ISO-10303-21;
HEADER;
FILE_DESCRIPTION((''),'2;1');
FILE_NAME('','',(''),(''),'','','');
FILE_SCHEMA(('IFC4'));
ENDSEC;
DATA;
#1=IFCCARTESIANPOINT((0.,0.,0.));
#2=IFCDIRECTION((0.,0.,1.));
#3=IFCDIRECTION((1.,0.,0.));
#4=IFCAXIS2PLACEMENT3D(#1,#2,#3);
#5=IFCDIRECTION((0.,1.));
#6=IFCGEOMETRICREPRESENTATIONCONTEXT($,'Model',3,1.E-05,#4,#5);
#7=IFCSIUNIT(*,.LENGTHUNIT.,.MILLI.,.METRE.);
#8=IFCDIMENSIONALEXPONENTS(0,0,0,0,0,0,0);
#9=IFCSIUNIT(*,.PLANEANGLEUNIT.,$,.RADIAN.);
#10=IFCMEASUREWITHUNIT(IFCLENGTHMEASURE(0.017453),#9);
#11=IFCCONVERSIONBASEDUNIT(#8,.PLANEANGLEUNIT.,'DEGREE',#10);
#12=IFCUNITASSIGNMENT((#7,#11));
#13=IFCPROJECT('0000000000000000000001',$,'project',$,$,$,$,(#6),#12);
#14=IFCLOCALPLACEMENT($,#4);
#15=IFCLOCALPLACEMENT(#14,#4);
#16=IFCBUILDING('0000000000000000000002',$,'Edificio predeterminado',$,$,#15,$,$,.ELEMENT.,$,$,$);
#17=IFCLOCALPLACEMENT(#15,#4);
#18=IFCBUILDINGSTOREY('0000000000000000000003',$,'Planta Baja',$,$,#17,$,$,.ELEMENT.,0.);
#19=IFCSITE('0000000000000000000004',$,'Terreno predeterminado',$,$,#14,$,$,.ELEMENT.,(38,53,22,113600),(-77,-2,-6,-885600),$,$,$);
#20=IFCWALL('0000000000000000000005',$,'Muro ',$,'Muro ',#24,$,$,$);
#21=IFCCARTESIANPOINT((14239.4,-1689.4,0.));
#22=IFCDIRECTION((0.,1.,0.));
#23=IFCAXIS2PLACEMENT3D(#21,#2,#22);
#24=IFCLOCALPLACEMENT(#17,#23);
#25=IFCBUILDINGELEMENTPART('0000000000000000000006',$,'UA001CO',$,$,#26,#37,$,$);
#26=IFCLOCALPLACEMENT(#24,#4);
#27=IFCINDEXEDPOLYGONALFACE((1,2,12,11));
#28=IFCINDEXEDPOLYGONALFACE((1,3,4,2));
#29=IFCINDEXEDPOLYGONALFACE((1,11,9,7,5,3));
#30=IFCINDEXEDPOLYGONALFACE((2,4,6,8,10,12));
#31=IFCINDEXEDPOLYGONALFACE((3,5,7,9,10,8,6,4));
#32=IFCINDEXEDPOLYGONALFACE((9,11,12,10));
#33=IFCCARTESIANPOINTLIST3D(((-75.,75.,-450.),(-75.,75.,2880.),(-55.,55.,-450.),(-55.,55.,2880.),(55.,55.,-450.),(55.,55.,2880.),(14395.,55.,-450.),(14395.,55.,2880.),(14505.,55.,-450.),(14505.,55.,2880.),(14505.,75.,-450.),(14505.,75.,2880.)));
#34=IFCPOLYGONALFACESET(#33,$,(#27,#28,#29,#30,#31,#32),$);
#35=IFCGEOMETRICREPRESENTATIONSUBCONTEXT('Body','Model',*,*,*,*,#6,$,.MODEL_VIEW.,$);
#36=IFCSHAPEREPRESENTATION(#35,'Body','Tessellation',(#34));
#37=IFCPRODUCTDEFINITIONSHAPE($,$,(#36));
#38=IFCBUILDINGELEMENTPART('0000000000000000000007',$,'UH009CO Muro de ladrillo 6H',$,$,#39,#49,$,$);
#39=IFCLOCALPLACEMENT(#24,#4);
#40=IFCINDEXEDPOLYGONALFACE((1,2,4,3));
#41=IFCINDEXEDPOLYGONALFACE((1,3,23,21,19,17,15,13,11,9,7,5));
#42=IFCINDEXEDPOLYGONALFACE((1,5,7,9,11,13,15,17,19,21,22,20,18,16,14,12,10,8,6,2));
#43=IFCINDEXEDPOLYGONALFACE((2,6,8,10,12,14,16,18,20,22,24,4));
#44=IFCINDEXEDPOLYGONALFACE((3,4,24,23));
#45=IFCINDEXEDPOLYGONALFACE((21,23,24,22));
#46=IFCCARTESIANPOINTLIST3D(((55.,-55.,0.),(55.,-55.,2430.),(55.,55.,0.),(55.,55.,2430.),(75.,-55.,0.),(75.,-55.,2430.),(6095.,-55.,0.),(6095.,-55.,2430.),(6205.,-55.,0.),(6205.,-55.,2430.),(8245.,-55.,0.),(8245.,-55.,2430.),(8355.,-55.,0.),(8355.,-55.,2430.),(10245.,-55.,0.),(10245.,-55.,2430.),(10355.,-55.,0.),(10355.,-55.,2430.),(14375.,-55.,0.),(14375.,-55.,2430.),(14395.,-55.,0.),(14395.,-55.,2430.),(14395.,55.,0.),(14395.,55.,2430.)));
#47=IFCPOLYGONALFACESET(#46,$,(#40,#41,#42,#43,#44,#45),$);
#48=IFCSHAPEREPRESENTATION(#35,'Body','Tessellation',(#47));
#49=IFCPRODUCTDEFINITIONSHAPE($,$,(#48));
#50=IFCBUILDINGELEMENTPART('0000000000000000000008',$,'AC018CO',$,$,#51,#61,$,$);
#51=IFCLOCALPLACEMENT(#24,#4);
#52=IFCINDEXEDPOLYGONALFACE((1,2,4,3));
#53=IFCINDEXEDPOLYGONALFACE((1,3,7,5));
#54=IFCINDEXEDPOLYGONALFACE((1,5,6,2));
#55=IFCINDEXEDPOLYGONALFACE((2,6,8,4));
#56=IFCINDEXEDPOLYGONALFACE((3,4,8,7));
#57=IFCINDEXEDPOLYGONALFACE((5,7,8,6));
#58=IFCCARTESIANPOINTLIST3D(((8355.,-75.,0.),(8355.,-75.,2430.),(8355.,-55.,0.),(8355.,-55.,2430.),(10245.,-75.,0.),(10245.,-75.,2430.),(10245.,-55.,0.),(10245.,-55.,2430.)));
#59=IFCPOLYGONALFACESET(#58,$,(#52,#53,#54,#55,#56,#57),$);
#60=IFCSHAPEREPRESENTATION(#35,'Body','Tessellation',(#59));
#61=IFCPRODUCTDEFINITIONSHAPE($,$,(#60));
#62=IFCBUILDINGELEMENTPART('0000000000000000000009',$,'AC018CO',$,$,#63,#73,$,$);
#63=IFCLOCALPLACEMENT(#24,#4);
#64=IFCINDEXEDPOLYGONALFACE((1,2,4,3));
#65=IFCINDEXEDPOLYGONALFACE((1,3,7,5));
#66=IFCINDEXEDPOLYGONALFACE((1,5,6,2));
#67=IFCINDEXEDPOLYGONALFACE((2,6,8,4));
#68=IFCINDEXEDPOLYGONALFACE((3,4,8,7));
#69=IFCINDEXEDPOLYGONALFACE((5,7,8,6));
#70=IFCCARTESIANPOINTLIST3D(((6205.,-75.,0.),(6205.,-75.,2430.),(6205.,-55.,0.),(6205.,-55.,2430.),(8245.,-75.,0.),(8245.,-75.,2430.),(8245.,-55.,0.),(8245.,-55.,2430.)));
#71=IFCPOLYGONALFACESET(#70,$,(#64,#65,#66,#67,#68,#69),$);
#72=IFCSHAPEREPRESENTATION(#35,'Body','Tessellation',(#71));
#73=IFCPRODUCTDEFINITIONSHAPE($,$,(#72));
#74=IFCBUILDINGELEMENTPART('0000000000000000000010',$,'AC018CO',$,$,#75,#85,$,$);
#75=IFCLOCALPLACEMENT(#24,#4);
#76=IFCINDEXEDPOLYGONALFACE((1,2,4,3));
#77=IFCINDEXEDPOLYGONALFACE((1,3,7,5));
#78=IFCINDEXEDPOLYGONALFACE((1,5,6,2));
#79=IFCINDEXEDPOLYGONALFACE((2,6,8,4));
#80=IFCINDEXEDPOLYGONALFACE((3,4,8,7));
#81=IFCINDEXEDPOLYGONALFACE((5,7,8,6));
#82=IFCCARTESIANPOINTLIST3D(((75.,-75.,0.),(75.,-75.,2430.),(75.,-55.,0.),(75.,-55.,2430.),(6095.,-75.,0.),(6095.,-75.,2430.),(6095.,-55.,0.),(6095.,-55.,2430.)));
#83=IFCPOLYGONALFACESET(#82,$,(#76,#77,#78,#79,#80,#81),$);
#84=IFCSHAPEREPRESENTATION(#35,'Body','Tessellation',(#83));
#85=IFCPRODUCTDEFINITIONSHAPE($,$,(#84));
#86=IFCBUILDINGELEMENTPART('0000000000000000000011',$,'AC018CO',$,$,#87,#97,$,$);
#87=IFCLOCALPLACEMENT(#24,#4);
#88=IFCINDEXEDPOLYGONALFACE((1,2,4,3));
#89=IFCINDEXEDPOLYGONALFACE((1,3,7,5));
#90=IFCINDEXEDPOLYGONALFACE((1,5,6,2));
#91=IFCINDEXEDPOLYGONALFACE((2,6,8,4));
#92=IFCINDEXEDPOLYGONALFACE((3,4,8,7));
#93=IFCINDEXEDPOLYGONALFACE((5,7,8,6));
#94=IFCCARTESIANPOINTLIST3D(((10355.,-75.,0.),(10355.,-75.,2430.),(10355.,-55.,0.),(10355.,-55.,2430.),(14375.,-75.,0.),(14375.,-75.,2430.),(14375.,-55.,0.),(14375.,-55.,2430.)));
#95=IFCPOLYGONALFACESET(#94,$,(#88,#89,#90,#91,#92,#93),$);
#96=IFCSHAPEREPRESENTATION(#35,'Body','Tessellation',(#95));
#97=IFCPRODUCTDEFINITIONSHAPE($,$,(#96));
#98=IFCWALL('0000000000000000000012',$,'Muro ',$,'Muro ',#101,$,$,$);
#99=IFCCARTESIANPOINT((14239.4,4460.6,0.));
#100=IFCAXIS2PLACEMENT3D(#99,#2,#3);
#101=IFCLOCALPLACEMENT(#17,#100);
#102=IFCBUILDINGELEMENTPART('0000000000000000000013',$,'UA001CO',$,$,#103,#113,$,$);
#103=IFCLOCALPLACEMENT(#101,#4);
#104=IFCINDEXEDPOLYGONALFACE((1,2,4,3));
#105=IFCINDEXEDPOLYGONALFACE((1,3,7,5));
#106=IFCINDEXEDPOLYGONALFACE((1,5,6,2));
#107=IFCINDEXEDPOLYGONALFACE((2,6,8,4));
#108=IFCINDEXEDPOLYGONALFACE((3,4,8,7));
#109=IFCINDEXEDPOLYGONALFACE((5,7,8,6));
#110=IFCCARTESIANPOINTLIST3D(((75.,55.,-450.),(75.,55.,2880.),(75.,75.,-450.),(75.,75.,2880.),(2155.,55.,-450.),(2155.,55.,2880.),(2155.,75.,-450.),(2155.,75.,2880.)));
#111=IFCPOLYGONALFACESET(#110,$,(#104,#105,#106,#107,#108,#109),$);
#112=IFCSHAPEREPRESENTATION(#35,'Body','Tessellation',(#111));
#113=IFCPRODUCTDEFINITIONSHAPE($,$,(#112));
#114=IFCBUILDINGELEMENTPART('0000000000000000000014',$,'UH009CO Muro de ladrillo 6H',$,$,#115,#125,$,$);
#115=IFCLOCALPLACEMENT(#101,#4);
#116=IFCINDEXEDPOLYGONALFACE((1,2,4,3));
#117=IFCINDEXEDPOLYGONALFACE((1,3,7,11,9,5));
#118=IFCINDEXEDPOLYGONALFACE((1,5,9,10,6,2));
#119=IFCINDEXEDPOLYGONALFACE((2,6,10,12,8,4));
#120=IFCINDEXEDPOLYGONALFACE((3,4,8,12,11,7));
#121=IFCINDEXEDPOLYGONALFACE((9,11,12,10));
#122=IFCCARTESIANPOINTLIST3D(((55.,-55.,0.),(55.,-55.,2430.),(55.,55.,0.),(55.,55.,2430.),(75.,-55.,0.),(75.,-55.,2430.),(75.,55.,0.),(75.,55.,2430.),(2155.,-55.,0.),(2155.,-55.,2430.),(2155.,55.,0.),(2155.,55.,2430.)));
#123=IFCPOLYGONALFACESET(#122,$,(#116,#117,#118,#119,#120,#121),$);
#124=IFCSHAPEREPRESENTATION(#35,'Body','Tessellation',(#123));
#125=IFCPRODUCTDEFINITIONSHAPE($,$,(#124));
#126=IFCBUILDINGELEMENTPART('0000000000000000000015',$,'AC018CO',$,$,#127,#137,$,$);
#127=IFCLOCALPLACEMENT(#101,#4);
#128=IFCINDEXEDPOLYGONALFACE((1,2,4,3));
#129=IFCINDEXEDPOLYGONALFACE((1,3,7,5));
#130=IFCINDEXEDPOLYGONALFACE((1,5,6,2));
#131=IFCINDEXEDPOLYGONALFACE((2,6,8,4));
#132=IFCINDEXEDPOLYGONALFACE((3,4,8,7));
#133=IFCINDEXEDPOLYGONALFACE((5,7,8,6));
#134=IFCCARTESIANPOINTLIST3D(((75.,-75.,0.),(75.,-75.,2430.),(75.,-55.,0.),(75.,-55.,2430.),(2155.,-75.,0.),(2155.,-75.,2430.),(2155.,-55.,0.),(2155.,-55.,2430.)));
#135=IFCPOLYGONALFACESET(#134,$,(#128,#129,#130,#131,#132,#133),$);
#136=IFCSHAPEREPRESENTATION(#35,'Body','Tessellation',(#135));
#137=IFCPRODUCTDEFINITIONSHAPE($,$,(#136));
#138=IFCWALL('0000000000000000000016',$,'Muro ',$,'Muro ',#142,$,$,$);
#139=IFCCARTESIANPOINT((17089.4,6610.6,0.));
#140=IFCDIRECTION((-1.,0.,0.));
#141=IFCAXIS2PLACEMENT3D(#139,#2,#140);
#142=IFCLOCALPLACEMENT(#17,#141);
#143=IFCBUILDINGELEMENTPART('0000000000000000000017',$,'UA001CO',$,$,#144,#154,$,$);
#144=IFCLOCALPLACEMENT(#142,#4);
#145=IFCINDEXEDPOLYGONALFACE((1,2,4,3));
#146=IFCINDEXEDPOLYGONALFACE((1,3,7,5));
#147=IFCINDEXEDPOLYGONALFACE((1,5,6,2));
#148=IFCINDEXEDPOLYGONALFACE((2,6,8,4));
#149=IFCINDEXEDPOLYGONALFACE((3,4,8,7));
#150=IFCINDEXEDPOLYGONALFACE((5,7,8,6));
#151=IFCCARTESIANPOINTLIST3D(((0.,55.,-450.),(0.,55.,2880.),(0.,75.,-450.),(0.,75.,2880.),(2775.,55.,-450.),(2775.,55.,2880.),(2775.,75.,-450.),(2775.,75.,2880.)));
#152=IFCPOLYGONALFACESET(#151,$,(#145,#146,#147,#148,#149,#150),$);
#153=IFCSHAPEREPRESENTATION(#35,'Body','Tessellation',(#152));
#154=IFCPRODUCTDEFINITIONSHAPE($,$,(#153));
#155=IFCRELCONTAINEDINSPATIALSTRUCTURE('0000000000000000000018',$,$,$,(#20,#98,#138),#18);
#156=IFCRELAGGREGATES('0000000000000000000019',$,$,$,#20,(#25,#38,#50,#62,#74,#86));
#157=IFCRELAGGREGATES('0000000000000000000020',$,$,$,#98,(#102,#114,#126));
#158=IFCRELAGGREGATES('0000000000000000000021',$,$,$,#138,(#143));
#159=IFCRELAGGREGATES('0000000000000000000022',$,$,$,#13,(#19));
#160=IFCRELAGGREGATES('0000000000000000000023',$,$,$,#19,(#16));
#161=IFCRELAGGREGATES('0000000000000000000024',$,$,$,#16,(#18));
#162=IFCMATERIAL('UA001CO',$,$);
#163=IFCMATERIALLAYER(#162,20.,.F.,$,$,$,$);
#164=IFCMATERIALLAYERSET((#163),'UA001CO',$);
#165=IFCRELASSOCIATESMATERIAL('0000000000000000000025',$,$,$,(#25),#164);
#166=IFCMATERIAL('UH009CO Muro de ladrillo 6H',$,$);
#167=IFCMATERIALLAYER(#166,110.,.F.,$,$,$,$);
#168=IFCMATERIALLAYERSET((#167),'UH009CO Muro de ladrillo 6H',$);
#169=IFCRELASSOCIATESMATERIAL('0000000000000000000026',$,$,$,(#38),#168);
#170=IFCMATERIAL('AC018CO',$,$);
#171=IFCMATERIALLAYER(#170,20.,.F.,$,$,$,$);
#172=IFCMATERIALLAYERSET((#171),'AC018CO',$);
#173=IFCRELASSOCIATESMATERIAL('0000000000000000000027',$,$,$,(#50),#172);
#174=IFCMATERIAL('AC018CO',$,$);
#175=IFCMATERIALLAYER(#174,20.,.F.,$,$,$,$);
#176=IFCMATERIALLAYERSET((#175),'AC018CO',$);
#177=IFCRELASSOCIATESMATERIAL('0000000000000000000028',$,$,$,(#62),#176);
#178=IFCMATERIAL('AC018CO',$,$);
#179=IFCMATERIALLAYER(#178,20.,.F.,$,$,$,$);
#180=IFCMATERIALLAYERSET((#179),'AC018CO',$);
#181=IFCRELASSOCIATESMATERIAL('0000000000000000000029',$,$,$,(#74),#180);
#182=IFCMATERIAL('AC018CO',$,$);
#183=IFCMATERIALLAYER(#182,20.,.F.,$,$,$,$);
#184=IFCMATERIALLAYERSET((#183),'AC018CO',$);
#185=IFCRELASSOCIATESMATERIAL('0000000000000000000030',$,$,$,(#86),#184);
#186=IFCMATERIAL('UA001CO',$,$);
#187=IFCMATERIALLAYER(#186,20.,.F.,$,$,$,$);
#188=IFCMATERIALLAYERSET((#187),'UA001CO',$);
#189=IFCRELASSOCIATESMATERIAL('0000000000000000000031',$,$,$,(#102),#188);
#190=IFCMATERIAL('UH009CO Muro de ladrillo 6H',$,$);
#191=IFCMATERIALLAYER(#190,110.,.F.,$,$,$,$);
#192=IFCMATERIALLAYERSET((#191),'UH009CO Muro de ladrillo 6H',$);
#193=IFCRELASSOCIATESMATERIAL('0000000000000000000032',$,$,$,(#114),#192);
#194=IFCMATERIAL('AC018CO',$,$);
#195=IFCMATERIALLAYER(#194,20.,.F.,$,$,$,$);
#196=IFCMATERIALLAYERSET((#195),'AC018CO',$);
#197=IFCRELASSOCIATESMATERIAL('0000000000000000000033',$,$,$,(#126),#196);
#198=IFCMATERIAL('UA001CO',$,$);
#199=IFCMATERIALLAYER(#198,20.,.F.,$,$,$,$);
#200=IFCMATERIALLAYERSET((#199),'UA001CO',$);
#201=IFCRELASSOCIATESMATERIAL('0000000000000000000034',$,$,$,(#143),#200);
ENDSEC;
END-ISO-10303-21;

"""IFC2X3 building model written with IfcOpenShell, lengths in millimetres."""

from ifc_helpers import new_model, entity, si_unit, converted_unit, direction, frame, origin_with_axes, place, context, subcontext, project, spatial, polyline, outline, extrude, material, layer, layer_set, layer_usage, element, aggregate, save


model = new_model("IFC2X3")

# Units and contexts
model_context = context("Model", 3, precision=1e-05, world=origin_with_axes(), true_north=direction((0.0, 1.0)))
body_context = subcontext(model_context, "Body", "Model", "MODEL_VIEW")
ifc_project = project(units=[si_unit("LENGTHUNIT", "METRE", prefix="MILLI"), converted_unit("PLANEANGLEUNIT", "DEGREE", entity("IfcLengthMeasure", 0.017453), si_unit("PLANEANGLEUNIT", "RADIAN"), dimensions=[0, 0, 0, 0, 0, 0, 0])], contexts=[model_context])

# Site, building, storey
site_placement = place(None, origin_with_axes())
site = spatial("IfcSite", under=ifc_project, at=site_placement, Name="Terreno predeterminado", CompositionType="ELEMENT", RefLatitude=(38, 53, 22, 113600), RefLongitude=(-77, -2, -6, -885600))
building_placement = place(site_placement, origin_with_axes())
building = spatial("IfcBuilding", under=site, at=building_placement, Name="Edificio predeterminado", CompositionType="ELEMENT")
storey_placement = place(building_placement, origin_with_axes())
storey = spatial("IfcBuildingStorey", under=building, at=storey_placement, Name="Planta Baja", CompositionType="ELEMENT", Elevation=0.0)

# Walls, building element parts
wall_1_placement = place(storey_placement, frame((14239.4, -1689.4, 0.0), z_axis=(0.0, 0.0, 1.0), x_axis=(0.0, 1.0, 0.0)))
wall_1 = element("IfcWall", 1, at=wall_1_placement, inside=storey, Name="Muro ", ObjectType="Muro ")
ifc_material_1 = material(Name="UA001CO")
ifc_layer_1 = layer(ifc_material_1, 20.0, ventilated=False)
ifc_layer_set_1 = layer_set([ifc_layer_1], Name="UA001CO")
ifc_layer_usage_1 = layer_usage(ifc_layer_set_1, "AXIS2", "NEGATIVE", -75.0)
building_element_part_1_placement = place(wall_1_placement, origin_with_axes())
building_element_part_1 = element("IfcBuildingElementPart", 2, at=building_element_part_1_placement, material=ifc_layer_usage_1, Name="UA001CO", context=body_context, shape_type="SweptSolid", body=[
    extrude(outline(polyline([(14505.0, 75.0), (14505.0, 55.0), (14395.0, 55.0), (55.0, 55.0), (-55.0, 55.0), (-75.0, 75.0), (14505.0, 75.0)])), frame((0.0, 0.0, -450.0), z_axis=(0.0, 0.0, 1.0), x_axis=(1.0, 0.0, 0.0)), (0.0, 0.0, 1.0), 3330.0),
])
ifc_material_2 = material(Name="UH009CO Muro de ladrillo 6H")
ifc_layer_2 = layer(ifc_material_2, 110.0, ventilated=False)
ifc_layer_set_2 = layer_set([ifc_layer_2], Name="UH009CO Muro de ladrillo 6H")
ifc_layer_usage_2 = layer_usage(ifc_layer_set_2, "AXIS2", "NEGATIVE", -55.0)
building_element_part_2_placement = place(wall_1_placement, origin_with_axes())
building_element_part_2 = element("IfcBuildingElementPart", 3, at=building_element_part_2_placement, material=ifc_layer_usage_2, Name="UH009CO Muro de ladrillo 6H", context=body_context, shape_type="SweptSolid", body=[
    extrude(outline(polyline([(14395.0, 55.0), (14395.0, -55.0), (14375.0, -55.0), (10355.0, -55.0), (10245.0, -55.0), (8355.0, -55.0), (8245.0, -55.0), (6205.0, -55.0), (6095.0, -55.0), (75.0, -55.0), (55.0, -55.0), (55.0, 55.0), (14395.0, 55.0)])), origin_with_axes(), (0.0, 0.0, 1.0), 2430.0),
])
ifc_material_3 = material(Name="AC018CO")
ifc_layer_3 = layer(ifc_material_3, 20.0, ventilated=False)
ifc_layer_set_3 = layer_set([ifc_layer_3], Name="AC018CO")
ifc_layer_usage_3 = layer_usage(ifc_layer_set_3, "AXIS2", "NEGATIVE", 55.0)
building_element_part_3_placement = place(wall_1_placement, origin_with_axes())
building_element_part_3 = element("IfcBuildingElementPart", 4, at=building_element_part_3_placement, material=ifc_layer_usage_3, Name="AC018CO", context=body_context, shape_type="SweptSolid", body=[
    extrude(outline(polyline([(8355.0, -55.0), (10245.0, -55.0), (10245.0, -75.0), (8355.0, -75.0), (8355.0, -55.0)])), origin_with_axes(), (0.0, 0.0, 1.0), 2430.0),
])
ifc_material_4 = material(Name="AC018CO")
ifc_layer_4 = layer(ifc_material_4, 20.0, ventilated=False)
ifc_layer_set_4 = layer_set([ifc_layer_4], Name="AC018CO")
ifc_layer_usage_4 = layer_usage(ifc_layer_set_4, "AXIS2", "NEGATIVE", 55.0)
building_element_part_4_placement = place(wall_1_placement, origin_with_axes())
building_element_part_4 = element("IfcBuildingElementPart", 5, at=building_element_part_4_placement, material=ifc_layer_usage_4, Name="AC018CO", context=body_context, shape_type="SweptSolid", body=[
    extrude(outline(polyline([(8245.0, -55.0), (8245.0, -75.0), (6205.0, -75.0), (6205.0, -55.0), (8245.0, -55.0)])), origin_with_axes(), (0.0, 0.0, 1.0), 2430.0),
])
ifc_material_5 = material(Name="AC018CO")
ifc_layer_5 = layer(ifc_material_5, 20.0, ventilated=False)
ifc_layer_set_5 = layer_set([ifc_layer_5], Name="AC018CO")
ifc_layer_usage_5 = layer_usage(ifc_layer_set_5, "AXIS2", "NEGATIVE", 55.0)
building_element_part_5_placement = place(wall_1_placement, origin_with_axes())
building_element_part_5 = element("IfcBuildingElementPart", 6, at=building_element_part_5_placement, material=ifc_layer_usage_5, Name="AC018CO", context=body_context, shape_type="SweptSolid", body=[
    extrude(outline(polyline([(6095.0, -55.0), (6095.0, -75.0), (75.0, -75.0), (75.0, -55.0), (6095.0, -55.0)])), origin_with_axes(), (0.0, 0.0, 1.0), 2430.0),
])
ifc_material_6 = material(Name="AC018CO")
ifc_layer_6 = layer(ifc_material_6, 20.0, ventilated=False)
ifc_layer_set_6 = layer_set([ifc_layer_6], Name="AC018CO")
ifc_layer_usage_6 = layer_usage(ifc_layer_set_6, "AXIS2", "NEGATIVE", 55.0)
building_element_part_6_placement = place(wall_1_placement, origin_with_axes())
building_element_part_6 = element("IfcBuildingElementPart", 7, at=building_element_part_6_placement, material=ifc_layer_usage_6, Name="AC018CO", context=body_context, shape_type="SweptSolid", body=[
    extrude(outline(polyline([(14375.0, -55.0), (14375.0, -75.0), (10355.0, -75.0), (10355.0, -55.0), (14375.0, -55.0)])), origin_with_axes(), (0.0, 0.0, 1.0), 2430.0),
])
aggregate(wall_1, [building_element_part_1, building_element_part_2, building_element_part_3, building_element_part_4, building_element_part_5, building_element_part_6])
wall_2_placement = place(storey_placement, frame((14239.4, 4460.6, 0.0), z_axis=(0.0, 0.0, 1.0), x_axis=(1.0, 0.0, 0.0)))
wall_2 = element("IfcWall", 8, at=wall_2_placement, inside=storey, Name="Muro ", ObjectType="Muro ")
ifc_material_7 = material(Name="UA001CO")
ifc_layer_7 = layer(ifc_material_7, 20.0, ventilated=False)
ifc_layer_set_7 = layer_set([ifc_layer_7], Name="UA001CO")
ifc_layer_usage_7 = layer_usage(ifc_layer_set_7, "AXIS2", "NEGATIVE", -75.0)
building_element_part_7_placement = place(wall_2_placement, origin_with_axes())
building_element_part_7 = element("IfcBuildingElementPart", 9, at=building_element_part_7_placement, material=ifc_layer_usage_7, Name="UA001CO", context=body_context, shape_type="SweptSolid", body=[
    extrude(outline(polyline([(2155.0, 75.0), (2155.0, 55.0), (75.0, 55.0), (75.0, 75.0), (2155.0, 75.0)])), frame((0.0, 0.0, -450.0), z_axis=(0.0, 0.0, 1.0), x_axis=(1.0, 0.0, 0.0)), (0.0, 0.0, 1.0), 3330.0),
])
ifc_material_8 = material(Name="UH009CO Muro de ladrillo 6H")
ifc_layer_8 = layer(ifc_material_8, 110.0, ventilated=False)
ifc_layer_set_8 = layer_set([ifc_layer_8], Name="UH009CO Muro de ladrillo 6H")
ifc_layer_usage_8 = layer_usage(ifc_layer_set_8, "AXIS2", "NEGATIVE", -55.0)
building_element_part_8_placement = place(wall_2_placement, origin_with_axes())
building_element_part_8 = element("IfcBuildingElementPart", 10, at=building_element_part_8_placement, material=ifc_layer_usage_8, Name="UH009CO Muro de ladrillo 6H", context=body_context, shape_type="SweptSolid", body=[
    extrude(outline(polyline([(2155.0, 55.0), (2155.0, -55.0), (75.0, -55.0), (55.0, -55.0), (55.0, 55.0), (75.0, 55.0), (2155.0, 55.0)])), origin_with_axes(), (0.0, 0.0, 1.0), 2430.0),
])
ifc_material_9 = material(Name="AC018CO")
ifc_layer_9 = layer(ifc_material_9, 20.0, ventilated=False)
ifc_layer_set_9 = layer_set([ifc_layer_9], Name="AC018CO")
ifc_layer_usage_9 = layer_usage(ifc_layer_set_9, "AXIS2", "NEGATIVE", 55.0)
building_element_part_9_placement = place(wall_2_placement, origin_with_axes())
building_element_part_9 = element("IfcBuildingElementPart", 11, at=building_element_part_9_placement, material=ifc_layer_usage_9, Name="AC018CO", context=body_context, shape_type="SweptSolid", body=[
    extrude(outline(polyline([(2155.0, -55.0), (2155.0, -75.0), (75.0, -75.0), (75.0, -55.0), (2155.0, -55.0)])), origin_with_axes(), (0.0, 0.0, 1.0), 2430.0),
])
aggregate(wall_2, [building_element_part_7, building_element_part_8, building_element_part_9])

# Wall, building element part
wall_3_placement = place(storey_placement, frame((17089.4, 6610.6, 0.0), z_axis=(0.0, 0.0, 1.0), x_axis=(-1.0, 0.0, 0.0)))
wall_3 = element("IfcWall", 12, at=wall_3_placement, inside=storey, Name="Muro ", ObjectType="Muro ")
ifc_material_10 = material(Name="UA001CO")
ifc_layer_10 = layer(ifc_material_10, 20.0, ventilated=False)
ifc_layer_set_10 = layer_set([ifc_layer_10], Name="UA001CO")
ifc_layer_usage_10 = layer_usage(ifc_layer_set_10, "AXIS2", "NEGATIVE", -75.0)
building_element_part_10_placement = place(wall_3_placement, origin_with_axes())
building_element_part_10 = element("IfcBuildingElementPart", 13, at=building_element_part_10_placement, material=ifc_layer_usage_10, Name="UA001CO", context=body_context, shape_type="SweptSolid", body=[
    extrude(outline(polyline([(0.0, 75.0), (2775.0, 75.0), (2775.0, 55.0), (0.0, 55.0), (0.0, 75.0)])), frame((0.0, 0.0, -450.0), z_axis=(0.0, 0.0, 1.0), x_axis=(1.0, 0.0, 0.0)), (0.0, 0.0, 1.0), 3330.0),
])
aggregate(wall_3, [building_element_part_10])

save(model, "model.ifc")
